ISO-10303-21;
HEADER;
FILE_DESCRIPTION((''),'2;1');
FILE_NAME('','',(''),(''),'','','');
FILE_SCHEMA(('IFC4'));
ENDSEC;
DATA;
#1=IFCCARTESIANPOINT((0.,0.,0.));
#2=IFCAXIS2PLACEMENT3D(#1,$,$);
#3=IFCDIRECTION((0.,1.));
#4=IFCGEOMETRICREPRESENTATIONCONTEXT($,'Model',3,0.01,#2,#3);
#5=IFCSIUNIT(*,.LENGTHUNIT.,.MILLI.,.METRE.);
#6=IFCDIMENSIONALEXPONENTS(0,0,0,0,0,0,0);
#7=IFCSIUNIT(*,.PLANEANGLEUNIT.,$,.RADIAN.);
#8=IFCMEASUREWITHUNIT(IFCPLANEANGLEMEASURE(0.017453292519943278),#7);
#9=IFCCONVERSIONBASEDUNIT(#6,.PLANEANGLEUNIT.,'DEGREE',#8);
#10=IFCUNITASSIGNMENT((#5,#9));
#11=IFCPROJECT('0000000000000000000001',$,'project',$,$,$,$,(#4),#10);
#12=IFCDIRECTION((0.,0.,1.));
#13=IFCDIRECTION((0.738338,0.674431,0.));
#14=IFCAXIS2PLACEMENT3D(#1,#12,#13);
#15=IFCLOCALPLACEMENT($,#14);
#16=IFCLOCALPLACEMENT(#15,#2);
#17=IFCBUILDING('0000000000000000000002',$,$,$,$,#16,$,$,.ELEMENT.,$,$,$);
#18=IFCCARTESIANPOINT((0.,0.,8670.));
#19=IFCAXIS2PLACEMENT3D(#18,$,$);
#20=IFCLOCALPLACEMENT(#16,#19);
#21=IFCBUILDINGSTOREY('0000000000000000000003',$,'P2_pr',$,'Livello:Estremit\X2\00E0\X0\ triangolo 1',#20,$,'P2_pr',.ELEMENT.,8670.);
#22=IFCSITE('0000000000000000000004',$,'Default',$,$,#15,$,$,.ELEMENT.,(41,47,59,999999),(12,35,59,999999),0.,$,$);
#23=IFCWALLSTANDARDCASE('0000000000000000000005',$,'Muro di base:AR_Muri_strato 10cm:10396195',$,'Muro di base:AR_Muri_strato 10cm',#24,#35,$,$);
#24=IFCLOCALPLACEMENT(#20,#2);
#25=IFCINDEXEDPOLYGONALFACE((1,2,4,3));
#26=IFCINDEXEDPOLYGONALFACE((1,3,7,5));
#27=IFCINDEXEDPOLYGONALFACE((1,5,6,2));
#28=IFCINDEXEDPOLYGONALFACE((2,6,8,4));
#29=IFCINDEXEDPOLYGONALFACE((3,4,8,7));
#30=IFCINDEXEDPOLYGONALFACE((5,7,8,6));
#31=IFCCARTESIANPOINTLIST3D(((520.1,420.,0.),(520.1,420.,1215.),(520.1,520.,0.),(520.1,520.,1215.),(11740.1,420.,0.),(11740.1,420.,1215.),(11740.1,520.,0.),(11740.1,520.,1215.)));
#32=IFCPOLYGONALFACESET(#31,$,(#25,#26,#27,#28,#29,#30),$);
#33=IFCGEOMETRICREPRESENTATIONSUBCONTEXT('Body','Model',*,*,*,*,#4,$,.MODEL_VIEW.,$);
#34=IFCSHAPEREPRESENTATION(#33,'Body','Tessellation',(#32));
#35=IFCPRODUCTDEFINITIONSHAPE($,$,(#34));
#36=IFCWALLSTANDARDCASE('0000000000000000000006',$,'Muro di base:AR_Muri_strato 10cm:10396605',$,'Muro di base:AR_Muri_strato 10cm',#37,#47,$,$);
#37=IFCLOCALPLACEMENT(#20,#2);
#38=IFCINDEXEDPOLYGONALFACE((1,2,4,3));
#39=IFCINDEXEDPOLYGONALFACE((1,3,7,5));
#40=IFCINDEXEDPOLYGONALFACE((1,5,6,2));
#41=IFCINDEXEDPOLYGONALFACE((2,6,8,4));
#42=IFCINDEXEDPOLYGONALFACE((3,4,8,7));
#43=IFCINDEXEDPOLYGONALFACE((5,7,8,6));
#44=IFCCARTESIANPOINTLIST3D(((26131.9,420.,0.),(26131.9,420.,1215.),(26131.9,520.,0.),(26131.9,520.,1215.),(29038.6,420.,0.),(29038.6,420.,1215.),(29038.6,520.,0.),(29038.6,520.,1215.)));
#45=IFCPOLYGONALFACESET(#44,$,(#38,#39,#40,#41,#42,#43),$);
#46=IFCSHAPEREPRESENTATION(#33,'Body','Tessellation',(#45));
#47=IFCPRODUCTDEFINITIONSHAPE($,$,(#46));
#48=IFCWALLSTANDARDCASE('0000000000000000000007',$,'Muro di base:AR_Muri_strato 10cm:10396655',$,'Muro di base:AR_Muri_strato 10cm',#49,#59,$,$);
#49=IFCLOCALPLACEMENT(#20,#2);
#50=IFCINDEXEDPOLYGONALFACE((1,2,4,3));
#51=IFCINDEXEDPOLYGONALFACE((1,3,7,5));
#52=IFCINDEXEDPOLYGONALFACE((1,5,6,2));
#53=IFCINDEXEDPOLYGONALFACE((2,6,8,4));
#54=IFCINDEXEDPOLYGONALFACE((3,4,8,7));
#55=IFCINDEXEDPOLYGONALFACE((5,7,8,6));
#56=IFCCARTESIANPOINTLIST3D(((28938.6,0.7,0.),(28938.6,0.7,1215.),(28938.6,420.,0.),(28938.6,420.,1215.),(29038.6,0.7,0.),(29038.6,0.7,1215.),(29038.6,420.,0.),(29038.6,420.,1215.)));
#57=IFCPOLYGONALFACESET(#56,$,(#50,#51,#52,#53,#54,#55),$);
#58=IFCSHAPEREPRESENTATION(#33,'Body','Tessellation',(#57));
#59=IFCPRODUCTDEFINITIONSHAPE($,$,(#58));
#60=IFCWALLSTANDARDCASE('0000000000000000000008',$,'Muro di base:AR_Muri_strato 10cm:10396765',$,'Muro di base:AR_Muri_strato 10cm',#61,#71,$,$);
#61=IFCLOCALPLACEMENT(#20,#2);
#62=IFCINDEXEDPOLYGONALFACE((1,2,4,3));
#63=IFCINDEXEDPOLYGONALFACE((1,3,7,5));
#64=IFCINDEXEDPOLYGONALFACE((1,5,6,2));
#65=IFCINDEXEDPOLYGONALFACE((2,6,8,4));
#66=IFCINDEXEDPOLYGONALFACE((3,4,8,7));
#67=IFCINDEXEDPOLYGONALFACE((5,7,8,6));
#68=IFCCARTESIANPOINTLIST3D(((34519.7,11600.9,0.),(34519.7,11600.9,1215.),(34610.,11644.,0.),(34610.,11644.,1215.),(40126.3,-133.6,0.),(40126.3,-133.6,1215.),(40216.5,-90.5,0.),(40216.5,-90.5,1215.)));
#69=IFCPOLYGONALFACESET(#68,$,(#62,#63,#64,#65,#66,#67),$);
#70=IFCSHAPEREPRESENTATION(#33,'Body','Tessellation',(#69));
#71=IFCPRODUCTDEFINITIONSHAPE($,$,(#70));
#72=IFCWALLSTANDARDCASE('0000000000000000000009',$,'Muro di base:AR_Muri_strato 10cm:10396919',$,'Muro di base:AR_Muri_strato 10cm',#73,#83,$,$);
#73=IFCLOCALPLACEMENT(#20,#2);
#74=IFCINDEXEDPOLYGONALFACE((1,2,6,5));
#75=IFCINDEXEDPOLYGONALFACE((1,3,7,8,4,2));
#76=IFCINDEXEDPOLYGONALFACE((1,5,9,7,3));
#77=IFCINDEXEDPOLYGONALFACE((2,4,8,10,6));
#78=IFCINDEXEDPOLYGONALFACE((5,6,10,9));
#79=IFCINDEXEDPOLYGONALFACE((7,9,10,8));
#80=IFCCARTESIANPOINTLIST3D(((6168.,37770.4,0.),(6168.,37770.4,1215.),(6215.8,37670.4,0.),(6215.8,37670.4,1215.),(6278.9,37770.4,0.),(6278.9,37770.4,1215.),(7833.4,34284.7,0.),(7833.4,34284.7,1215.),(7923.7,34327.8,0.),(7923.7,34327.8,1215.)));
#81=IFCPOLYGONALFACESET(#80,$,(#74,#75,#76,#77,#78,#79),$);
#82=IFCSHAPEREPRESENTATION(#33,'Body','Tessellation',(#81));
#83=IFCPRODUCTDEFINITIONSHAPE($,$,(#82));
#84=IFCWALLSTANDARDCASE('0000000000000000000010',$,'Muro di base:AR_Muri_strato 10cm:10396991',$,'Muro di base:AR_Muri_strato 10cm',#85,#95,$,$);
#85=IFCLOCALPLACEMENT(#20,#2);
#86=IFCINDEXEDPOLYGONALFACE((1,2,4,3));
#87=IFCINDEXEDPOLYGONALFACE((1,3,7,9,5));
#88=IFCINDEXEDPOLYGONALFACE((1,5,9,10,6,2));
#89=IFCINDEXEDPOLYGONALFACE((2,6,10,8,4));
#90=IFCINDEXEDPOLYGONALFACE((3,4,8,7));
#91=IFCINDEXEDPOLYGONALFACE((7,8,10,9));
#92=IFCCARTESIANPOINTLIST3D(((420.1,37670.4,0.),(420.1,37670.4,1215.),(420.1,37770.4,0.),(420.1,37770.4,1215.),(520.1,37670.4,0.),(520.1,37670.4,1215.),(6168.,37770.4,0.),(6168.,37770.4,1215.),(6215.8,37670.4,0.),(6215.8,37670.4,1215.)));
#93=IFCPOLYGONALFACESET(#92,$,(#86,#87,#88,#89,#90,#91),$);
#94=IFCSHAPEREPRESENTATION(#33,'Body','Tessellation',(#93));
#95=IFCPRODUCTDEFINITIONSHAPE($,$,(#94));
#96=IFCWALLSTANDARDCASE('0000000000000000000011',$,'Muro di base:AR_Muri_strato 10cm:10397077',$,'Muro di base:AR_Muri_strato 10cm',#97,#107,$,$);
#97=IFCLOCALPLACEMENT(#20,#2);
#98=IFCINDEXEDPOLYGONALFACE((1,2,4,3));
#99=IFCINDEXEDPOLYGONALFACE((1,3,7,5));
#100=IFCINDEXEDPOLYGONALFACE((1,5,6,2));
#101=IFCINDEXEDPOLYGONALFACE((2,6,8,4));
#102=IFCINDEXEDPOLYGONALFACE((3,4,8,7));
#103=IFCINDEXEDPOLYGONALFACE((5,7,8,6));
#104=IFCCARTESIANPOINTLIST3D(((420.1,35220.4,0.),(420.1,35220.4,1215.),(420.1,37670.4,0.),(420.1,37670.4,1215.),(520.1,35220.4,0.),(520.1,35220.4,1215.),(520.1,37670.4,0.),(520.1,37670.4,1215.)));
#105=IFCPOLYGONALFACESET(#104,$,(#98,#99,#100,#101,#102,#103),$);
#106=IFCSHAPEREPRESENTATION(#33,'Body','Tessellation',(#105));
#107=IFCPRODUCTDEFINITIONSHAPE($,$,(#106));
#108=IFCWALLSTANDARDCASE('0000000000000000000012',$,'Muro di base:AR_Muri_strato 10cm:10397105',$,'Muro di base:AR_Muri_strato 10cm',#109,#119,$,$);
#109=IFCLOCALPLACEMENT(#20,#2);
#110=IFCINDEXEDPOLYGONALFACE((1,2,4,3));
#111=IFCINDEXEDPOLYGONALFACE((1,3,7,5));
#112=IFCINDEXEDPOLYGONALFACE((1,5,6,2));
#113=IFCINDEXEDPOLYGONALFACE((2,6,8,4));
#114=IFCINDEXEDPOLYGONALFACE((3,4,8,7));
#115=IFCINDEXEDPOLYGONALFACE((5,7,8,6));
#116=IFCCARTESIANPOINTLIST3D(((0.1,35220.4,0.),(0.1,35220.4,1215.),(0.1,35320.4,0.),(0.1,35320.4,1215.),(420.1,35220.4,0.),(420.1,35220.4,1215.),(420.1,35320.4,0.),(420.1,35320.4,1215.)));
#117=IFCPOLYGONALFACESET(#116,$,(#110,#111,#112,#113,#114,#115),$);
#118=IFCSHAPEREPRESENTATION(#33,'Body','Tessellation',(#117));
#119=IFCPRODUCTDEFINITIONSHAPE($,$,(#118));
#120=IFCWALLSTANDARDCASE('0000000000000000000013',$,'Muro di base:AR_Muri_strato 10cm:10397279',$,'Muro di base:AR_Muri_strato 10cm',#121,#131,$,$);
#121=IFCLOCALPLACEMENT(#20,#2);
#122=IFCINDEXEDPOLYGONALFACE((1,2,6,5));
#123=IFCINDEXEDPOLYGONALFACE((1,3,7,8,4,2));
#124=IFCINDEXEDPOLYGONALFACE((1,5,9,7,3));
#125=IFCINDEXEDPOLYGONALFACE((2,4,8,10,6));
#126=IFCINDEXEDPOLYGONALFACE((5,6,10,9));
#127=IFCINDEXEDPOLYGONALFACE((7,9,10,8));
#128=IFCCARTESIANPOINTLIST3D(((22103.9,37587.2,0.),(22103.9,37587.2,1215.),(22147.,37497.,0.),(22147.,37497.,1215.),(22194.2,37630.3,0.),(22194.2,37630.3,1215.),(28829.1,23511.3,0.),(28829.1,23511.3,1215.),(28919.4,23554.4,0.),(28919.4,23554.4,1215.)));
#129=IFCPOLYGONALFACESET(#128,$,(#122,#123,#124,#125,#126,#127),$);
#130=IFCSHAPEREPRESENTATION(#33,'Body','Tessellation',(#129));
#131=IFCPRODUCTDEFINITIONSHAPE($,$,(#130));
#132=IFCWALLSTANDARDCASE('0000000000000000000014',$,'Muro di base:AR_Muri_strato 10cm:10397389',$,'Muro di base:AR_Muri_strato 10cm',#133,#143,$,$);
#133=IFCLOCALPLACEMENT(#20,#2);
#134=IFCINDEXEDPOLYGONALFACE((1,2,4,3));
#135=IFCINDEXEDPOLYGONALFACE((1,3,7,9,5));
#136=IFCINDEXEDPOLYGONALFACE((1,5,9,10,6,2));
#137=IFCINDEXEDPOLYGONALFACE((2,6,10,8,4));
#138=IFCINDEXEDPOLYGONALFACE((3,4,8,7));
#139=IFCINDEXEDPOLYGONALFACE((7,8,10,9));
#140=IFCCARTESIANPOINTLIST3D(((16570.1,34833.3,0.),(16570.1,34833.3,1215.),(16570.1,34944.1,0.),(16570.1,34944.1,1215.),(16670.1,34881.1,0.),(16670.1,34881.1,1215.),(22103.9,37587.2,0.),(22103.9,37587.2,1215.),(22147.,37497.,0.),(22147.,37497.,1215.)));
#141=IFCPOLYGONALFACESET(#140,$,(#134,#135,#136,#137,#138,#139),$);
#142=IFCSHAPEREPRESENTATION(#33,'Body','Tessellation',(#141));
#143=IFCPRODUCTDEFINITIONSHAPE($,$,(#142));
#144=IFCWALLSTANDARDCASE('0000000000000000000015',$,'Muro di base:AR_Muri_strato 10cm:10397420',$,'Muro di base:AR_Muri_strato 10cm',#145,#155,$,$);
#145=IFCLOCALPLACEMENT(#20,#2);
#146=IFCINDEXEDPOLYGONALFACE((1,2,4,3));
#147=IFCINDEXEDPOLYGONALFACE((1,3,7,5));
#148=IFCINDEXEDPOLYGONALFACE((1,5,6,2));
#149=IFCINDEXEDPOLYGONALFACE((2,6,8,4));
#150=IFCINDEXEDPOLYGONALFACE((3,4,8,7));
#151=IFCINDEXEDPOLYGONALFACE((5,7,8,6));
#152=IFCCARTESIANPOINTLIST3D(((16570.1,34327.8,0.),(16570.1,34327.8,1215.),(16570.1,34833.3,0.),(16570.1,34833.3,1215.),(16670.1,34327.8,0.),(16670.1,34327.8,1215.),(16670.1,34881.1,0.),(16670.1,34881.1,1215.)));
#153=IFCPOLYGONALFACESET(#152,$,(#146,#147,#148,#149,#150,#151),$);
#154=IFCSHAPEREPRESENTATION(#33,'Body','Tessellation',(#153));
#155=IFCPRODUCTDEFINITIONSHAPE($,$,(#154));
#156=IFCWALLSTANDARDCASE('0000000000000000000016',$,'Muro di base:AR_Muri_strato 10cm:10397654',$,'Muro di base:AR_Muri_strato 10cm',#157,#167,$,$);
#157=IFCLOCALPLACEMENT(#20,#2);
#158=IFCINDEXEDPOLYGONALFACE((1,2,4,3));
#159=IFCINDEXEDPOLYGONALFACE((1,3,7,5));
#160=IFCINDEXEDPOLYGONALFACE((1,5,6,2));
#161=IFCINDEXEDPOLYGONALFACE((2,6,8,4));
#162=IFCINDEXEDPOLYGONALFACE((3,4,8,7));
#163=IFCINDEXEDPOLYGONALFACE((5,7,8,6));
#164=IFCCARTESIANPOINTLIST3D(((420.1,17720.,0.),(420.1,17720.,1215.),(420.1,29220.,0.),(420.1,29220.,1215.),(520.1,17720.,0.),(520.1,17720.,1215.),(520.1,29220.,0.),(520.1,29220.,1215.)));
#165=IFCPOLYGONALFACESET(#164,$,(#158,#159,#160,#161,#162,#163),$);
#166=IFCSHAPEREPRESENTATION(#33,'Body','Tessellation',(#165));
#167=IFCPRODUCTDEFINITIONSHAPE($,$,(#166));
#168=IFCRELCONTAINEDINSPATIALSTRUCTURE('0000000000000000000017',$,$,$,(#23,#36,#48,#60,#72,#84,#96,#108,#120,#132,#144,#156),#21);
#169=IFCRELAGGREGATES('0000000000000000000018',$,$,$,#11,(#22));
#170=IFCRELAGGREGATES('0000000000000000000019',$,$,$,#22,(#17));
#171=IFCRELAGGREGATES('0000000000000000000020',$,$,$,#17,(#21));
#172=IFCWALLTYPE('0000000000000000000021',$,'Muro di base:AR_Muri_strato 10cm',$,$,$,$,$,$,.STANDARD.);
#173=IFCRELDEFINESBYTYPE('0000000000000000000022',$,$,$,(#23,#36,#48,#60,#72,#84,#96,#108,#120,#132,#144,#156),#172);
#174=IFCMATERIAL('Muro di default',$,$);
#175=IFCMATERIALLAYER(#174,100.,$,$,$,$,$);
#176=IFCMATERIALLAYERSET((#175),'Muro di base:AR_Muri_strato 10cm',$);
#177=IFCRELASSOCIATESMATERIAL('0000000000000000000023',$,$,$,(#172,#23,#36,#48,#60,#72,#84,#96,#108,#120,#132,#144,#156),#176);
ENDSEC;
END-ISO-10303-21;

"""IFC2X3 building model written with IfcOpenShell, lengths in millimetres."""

from ifc_helpers import new_model, entity, si_unit, converted_unit, direction, frame, frame_2d, origin, place, context, subcontext, project, spatial, polyline, rectangle, outline, extrude, material, layer, layer_set, layer_usage, type_object, element, save


model = new_model("IFC2X3")

# Units and contexts
model_context = context("Model", 3, precision=0.01, world=origin(), true_north=direction((0.0, 1.0)))
body_context = subcontext(model_context, "Body", "Model", "MODEL_VIEW")
ifc_project = project(units=[si_unit("LENGTHUNIT", "METRE", prefix="MILLI"), converted_unit("PLANEANGLEUNIT", "DEGREE", entity("IfcPlaneAngleMeasure", 0.017453292519943278), si_unit("PLANEANGLEUNIT", "RADIAN"), dimensions=[0, 0, 0, 0, 0, 0, 0])], contexts=[model_context])

# Site, building, storey
site_placement = place(None, frame((0.0, 0.0, 0.0), z_axis=(0.0, 0.0, 1.0), x_axis=(0.738338, 0.674431, 0.0)))
site = spatial("IfcSite", under=ifc_project, at=site_placement, Name="Default", CompositionType="ELEMENT", RefLatitude=(41, 47, 59, 999999), RefLongitude=(12, 35, 59, 999999), RefElevation=0.0)
building_placement = place(site_placement, origin())
building = spatial("IfcBuilding", under=site, at=building_placement, CompositionType="ELEMENT")
storey_placement = place(building_placement, frame((0.0, 0.0, 8670.0)))
storey = spatial("IfcBuildingStorey", under=building, at=storey_placement, Name="P2_pr", ObjectType="Livello:Estremità triangolo 1", LongName="P2_pr", CompositionType="ELEMENT", Elevation=8670.0)

# Shared definitions
ifc_material = material(Name="Muro di default")
ifc_layer_1 = layer(ifc_material, 100.0)
ifc_layer_set_1 = layer_set([ifc_layer_1], Name="Muro di base:AR_Muri_strato 10cm")
wall_type_1 = type_object("IfcWallType", Name="Muro di base:AR_Muri_strato 10cm", PredefinedType="STANDARD", material=ifc_layer_set_1)

# Walls
ifc_layer_usage_1 = layer_usage(ifc_layer_set_1, "AXIS2", "NEGATIVE", 50.0)
wall_1_placement = place(storey_placement, frame((520.1, 470.0, 0.0)))
element("IfcWallStandardCase", 1, at=wall_1_placement, inside=storey, type_object=wall_type_1, material=ifc_layer_usage_1, Name="Muro di base:AR_Muri_strato 10cm:10396195", ObjectType="Muro di base:AR_Muri_strato 10cm", context=body_context, shape_type="SweptSolid", body=[
    extrude(rectangle(XDim=11220.0, YDim=100.0, at=frame_2d((5610.0, 0.0), x_axis=(-1.0, 0.0))), origin(), (0.0, 0.0, 1.0), 1215.0),
])
ifc_layer_usage_2 = layer_usage(ifc_layer_set_1, "AXIS2", "NEGATIVE", 50.0)
wall_2_placement = place(storey_placement, frame((26131.9, 470.0, 0.0)))
element("IfcWallStandardCase", 2, at=wall_2_placement, inside=storey, type_object=wall_type_1, material=ifc_layer_usage_2, Name="Muro di base:AR_Muri_strato 10cm:10396605", ObjectType="Muro di base:AR_Muri_strato 10cm", context=body_context, shape_type="SweptSolid", body=[
    extrude(rectangle(XDim=2906.7, YDim=100.0, at=frame_2d((1453.4, 0.0), x_axis=(-1.0, 0.0))), origin(), (0.0, 0.0, 1.0), 1215.0),
])
ifc_layer_usage_3 = layer_usage(ifc_layer_set_1, "AXIS2", "NEGATIVE", 50.0)
wall_3_placement = place(storey_placement, frame((28988.6, 420.0, 0.0), z_axis=(0.0, 0.0, 1.0), x_axis=(0.0, -1.0, 0.0)))
element("IfcWallStandardCase", 3, at=wall_3_placement, inside=storey, type_object=wall_type_1, material=ifc_layer_usage_3, Name="Muro di base:AR_Muri_strato 10cm:10396655", ObjectType="Muro di base:AR_Muri_strato 10cm", context=body_context, shape_type="SweptSolid", body=[
    extrude(rectangle(XDim=419.3, YDim=100.0, at=frame_2d((209.6, 0.0), x_axis=(-1.0, 0.0))), origin(), (0.0, 0.0, 1.0), 1215.0),
])
ifc_layer_usage_4 = layer_usage(ifc_layer_set_1, "AXIS2", "NEGATIVE", 50.0)
wall_4_placement = place(storey_placement, frame((40171.4, -112.1, 0.0), z_axis=(0.0, 0.0, 1.0), x_axis=(-0.431105, 0.902302, 0.0)))
element("IfcWallStandardCase", 4, at=wall_4_placement, inside=storey, type_object=wall_type_1, material=ifc_layer_usage_4, Name="Muro di base:AR_Muri_strato 10cm:10396765", ObjectType="Muro di base:AR_Muri_strato 10cm", context=body_context, shape_type="SweptSolid", body=[
    extrude(rectangle(XDim=13005.2, YDim=100.0, at=frame_2d((6502.6, 0.0), x_axis=(-1.0, 0.0))), origin(), (0.0, 0.0, 1.0), 1215.0),
])
ifc_layer_usage_5 = layer_usage(ifc_layer_set_1, "AXIS2", "NEGATIVE", 50.0)
wall_5_placement = place(storey_placement, frame((7878.6, 34306.2, 0.0), z_axis=(0.0, 0.0, 1.0), x_axis=(-0.431105, 0.902302, 0.0)))
element("IfcWallStandardCase", 5, at=wall_5_placement, inside=storey, type_object=wall_type_1, material=ifc_layer_usage_5, Name="Muro di base:AR_Muri_strato 10cm:10396919", ObjectType="Muro di base:AR_Muri_strato 10cm", context=body_context, shape_type="SweptSolid", body=[
    extrude(outline(polyline([(3815.3, -50.0), (3863.1, 50.0), (3752.3, 50.0), (0.0, 50.0), (0.0, -50.0), (3815.3, -50.0)])), origin(), (0.0, 0.0, 1.0), 1215.0),
])
ifc_layer_usage_6 = layer_usage(ifc_layer_set_1, "AXIS2", "NEGATIVE", 50.0)
wall_6_placement = place(storey_placement, frame((6215.8, 37720.4, 0.0), z_axis=(0.0, 0.0, 1.0), x_axis=(-1.0, 0.0, 0.0)))
element("IfcWallStandardCase", 6, at=wall_6_placement, inside=storey, type_object=wall_type_1, material=ifc_layer_usage_6, Name="Muro di base:AR_Muri_strato 10cm:10396991", ObjectType="Muro di base:AR_Muri_strato 10cm", context=body_context, shape_type="SweptSolid", body=[
    extrude(outline(polyline([(5795.7, -50.0), (5795.7, 50.0), (5695.7, 50.0), (0.0, 50.0), (47.8, -50.0), (5795.7, -50.0)])), origin(), (0.0, 0.0, 1.0), 1215.0),
])
ifc_layer_usage_7 = layer_usage(ifc_layer_set_1, "AXIS2", "NEGATIVE", 50.0)
wall_7_placement = place(storey_placement, frame((470.1, 37670.4, 0.0), z_axis=(0.0, 0.0, 1.0), x_axis=(0.0, -1.0, 0.0)))
element("IfcWallStandardCase", 7, at=wall_7_placement, inside=storey, type_object=wall_type_1, material=ifc_layer_usage_7, Name="Muro di base:AR_Muri_strato 10cm:10397077", ObjectType="Muro di base:AR_Muri_strato 10cm", context=body_context, shape_type="SweptSolid", body=[
    extrude(rectangle(XDim=2450.0, YDim=100.0, at=frame_2d((1225.0, 0.0), x_axis=(-1.0, 0.0))), origin(), (0.0, 0.0, 1.0), 1215.0),
])
ifc_layer_usage_8 = layer_usage(ifc_layer_set_1, "AXIS2", "NEGATIVE", 50.0)
wall_8_placement = place(storey_placement, frame((420.1, 35270.4, 0.0), z_axis=(0.0, 0.0, 1.0), x_axis=(-1.0, 0.0, 0.0)))
element("IfcWallStandardCase", 8, at=wall_8_placement, inside=storey, type_object=wall_type_1, material=ifc_layer_usage_8, Name="Muro di base:AR_Muri_strato 10cm:10397105", ObjectType="Muro di base:AR_Muri_strato 10cm", context=body_context, shape_type="SweptSolid", body=[
    extrude(rectangle(XDim=420.0, YDim=100.0, at=frame_2d((210.0, 0.0), x_axis=(-1.0, 0.0))), origin(), (0.0, 0.0, 1.0), 1215.0),
])
ifc_layer_usage_9 = layer_usage(ifc_layer_set_1, "AXIS2", "NEGATIVE", 50.0)
wall_9_placement = place(storey_placement, frame((28874.3, 23532.9, 0.0), z_axis=(0.0, 0.0, 1.0), x_axis=(-0.431103, 0.902303, 0.0)))
element("IfcWallStandardCase", 9, at=wall_9_placement, inside=storey, type_object=wall_type_1, material=ifc_layer_usage_9, Name="Muro di base:AR_Muri_strato 10cm:10397279", ObjectType="Muro di base:AR_Muri_strato 10cm", context=body_context, shape_type="SweptSolid", body=[
    extrude(outline(polyline([(15600.0, -50.0), (15600.0, 50.0), (15500.0, 50.0), (0.0, 50.0), (0.0, -50.0), (15600.0, -50.0)])), origin(), (0.0, 0.0, 1.0), 1215.0),
])
ifc_layer_usage_10 = layer_usage(ifc_layer_set_1, "AXIS2", "NEGATIVE", 50.0)
wall_10_placement = place(storey_placement, frame((22125.5, 37542.1, 0.0), z_axis=(0.0, 0.0, 1.0), x_axis=(-0.902358, -0.430987, 0.0)))
element("IfcWallStandardCase", 10, at=wall_10_placement, inside=storey, type_object=wall_type_1, material=ifc_layer_usage_10, Name="Muro di base:AR_Muri_strato 10cm:10397389", ObjectType="Muro di base:AR_Muri_strato 10cm", context=body_context, shape_type="SweptSolid", body=[
    extrude(outline(polyline([(6132.7, -50.0), (6180.4, 50.0), (6069.6, 50.0), (0.0, 50.0), (0.0, -50.0), (6132.7, -50.0)])), origin(), (0.0, 0.0, 1.0), 1215.0),
])
ifc_layer_usage_11 = layer_usage(ifc_layer_set_1, "AXIS2", "NEGATIVE", 50.0)
wall_11_placement = place(storey_placement, frame((16620.1, 34881.1, 0.0), z_axis=(0.0, 0.0, 1.0), x_axis=(0.0, -1.0, 0.0)))
element("IfcWallStandardCase", 11, at=wall_11_placement, inside=storey, type_object=wall_type_1, material=ifc_layer_usage_11, Name="Muro di base:AR_Muri_strato 10cm:10397420", ObjectType="Muro di base:AR_Muri_strato 10cm", context=body_context, shape_type="SweptSolid", body=[
    extrude(outline(polyline([(553.3, -50.0), (553.3, 50.0), (0.0, 50.0), (47.8, -50.0), (553.3, -50.0)])), origin(), (0.0, 0.0, 1.0), 1215.0),
])
ifc_layer_usage_12 = layer_usage(ifc_layer_set_1, "AXIS2", "NEGATIVE", 50.0)
wall_12_placement = place(storey_placement, frame((470.1, 29220.0, 0.0), z_axis=(0.0, 0.0, 1.0), x_axis=(0.000002, -1.0, 0.0)))
element("IfcWallStandardCase", 12, at=wall_12_placement, inside=storey, type_object=wall_type_1, material=ifc_layer_usage_12, Name="Muro di base:AR_Muri_strato 10cm:10397654", ObjectType="Muro di base:AR_Muri_strato 10cm", context=body_context, shape_type="SweptSolid", body=[
    extrude(rectangle(XDim=11500.0, YDim=100.0, at=frame_2d((5750.0, 0.0), x_axis=(-1.0, 0.0))), origin(), (0.0, 0.0, 1.0), 1215.0),
])

save(model, "model.ifc")
